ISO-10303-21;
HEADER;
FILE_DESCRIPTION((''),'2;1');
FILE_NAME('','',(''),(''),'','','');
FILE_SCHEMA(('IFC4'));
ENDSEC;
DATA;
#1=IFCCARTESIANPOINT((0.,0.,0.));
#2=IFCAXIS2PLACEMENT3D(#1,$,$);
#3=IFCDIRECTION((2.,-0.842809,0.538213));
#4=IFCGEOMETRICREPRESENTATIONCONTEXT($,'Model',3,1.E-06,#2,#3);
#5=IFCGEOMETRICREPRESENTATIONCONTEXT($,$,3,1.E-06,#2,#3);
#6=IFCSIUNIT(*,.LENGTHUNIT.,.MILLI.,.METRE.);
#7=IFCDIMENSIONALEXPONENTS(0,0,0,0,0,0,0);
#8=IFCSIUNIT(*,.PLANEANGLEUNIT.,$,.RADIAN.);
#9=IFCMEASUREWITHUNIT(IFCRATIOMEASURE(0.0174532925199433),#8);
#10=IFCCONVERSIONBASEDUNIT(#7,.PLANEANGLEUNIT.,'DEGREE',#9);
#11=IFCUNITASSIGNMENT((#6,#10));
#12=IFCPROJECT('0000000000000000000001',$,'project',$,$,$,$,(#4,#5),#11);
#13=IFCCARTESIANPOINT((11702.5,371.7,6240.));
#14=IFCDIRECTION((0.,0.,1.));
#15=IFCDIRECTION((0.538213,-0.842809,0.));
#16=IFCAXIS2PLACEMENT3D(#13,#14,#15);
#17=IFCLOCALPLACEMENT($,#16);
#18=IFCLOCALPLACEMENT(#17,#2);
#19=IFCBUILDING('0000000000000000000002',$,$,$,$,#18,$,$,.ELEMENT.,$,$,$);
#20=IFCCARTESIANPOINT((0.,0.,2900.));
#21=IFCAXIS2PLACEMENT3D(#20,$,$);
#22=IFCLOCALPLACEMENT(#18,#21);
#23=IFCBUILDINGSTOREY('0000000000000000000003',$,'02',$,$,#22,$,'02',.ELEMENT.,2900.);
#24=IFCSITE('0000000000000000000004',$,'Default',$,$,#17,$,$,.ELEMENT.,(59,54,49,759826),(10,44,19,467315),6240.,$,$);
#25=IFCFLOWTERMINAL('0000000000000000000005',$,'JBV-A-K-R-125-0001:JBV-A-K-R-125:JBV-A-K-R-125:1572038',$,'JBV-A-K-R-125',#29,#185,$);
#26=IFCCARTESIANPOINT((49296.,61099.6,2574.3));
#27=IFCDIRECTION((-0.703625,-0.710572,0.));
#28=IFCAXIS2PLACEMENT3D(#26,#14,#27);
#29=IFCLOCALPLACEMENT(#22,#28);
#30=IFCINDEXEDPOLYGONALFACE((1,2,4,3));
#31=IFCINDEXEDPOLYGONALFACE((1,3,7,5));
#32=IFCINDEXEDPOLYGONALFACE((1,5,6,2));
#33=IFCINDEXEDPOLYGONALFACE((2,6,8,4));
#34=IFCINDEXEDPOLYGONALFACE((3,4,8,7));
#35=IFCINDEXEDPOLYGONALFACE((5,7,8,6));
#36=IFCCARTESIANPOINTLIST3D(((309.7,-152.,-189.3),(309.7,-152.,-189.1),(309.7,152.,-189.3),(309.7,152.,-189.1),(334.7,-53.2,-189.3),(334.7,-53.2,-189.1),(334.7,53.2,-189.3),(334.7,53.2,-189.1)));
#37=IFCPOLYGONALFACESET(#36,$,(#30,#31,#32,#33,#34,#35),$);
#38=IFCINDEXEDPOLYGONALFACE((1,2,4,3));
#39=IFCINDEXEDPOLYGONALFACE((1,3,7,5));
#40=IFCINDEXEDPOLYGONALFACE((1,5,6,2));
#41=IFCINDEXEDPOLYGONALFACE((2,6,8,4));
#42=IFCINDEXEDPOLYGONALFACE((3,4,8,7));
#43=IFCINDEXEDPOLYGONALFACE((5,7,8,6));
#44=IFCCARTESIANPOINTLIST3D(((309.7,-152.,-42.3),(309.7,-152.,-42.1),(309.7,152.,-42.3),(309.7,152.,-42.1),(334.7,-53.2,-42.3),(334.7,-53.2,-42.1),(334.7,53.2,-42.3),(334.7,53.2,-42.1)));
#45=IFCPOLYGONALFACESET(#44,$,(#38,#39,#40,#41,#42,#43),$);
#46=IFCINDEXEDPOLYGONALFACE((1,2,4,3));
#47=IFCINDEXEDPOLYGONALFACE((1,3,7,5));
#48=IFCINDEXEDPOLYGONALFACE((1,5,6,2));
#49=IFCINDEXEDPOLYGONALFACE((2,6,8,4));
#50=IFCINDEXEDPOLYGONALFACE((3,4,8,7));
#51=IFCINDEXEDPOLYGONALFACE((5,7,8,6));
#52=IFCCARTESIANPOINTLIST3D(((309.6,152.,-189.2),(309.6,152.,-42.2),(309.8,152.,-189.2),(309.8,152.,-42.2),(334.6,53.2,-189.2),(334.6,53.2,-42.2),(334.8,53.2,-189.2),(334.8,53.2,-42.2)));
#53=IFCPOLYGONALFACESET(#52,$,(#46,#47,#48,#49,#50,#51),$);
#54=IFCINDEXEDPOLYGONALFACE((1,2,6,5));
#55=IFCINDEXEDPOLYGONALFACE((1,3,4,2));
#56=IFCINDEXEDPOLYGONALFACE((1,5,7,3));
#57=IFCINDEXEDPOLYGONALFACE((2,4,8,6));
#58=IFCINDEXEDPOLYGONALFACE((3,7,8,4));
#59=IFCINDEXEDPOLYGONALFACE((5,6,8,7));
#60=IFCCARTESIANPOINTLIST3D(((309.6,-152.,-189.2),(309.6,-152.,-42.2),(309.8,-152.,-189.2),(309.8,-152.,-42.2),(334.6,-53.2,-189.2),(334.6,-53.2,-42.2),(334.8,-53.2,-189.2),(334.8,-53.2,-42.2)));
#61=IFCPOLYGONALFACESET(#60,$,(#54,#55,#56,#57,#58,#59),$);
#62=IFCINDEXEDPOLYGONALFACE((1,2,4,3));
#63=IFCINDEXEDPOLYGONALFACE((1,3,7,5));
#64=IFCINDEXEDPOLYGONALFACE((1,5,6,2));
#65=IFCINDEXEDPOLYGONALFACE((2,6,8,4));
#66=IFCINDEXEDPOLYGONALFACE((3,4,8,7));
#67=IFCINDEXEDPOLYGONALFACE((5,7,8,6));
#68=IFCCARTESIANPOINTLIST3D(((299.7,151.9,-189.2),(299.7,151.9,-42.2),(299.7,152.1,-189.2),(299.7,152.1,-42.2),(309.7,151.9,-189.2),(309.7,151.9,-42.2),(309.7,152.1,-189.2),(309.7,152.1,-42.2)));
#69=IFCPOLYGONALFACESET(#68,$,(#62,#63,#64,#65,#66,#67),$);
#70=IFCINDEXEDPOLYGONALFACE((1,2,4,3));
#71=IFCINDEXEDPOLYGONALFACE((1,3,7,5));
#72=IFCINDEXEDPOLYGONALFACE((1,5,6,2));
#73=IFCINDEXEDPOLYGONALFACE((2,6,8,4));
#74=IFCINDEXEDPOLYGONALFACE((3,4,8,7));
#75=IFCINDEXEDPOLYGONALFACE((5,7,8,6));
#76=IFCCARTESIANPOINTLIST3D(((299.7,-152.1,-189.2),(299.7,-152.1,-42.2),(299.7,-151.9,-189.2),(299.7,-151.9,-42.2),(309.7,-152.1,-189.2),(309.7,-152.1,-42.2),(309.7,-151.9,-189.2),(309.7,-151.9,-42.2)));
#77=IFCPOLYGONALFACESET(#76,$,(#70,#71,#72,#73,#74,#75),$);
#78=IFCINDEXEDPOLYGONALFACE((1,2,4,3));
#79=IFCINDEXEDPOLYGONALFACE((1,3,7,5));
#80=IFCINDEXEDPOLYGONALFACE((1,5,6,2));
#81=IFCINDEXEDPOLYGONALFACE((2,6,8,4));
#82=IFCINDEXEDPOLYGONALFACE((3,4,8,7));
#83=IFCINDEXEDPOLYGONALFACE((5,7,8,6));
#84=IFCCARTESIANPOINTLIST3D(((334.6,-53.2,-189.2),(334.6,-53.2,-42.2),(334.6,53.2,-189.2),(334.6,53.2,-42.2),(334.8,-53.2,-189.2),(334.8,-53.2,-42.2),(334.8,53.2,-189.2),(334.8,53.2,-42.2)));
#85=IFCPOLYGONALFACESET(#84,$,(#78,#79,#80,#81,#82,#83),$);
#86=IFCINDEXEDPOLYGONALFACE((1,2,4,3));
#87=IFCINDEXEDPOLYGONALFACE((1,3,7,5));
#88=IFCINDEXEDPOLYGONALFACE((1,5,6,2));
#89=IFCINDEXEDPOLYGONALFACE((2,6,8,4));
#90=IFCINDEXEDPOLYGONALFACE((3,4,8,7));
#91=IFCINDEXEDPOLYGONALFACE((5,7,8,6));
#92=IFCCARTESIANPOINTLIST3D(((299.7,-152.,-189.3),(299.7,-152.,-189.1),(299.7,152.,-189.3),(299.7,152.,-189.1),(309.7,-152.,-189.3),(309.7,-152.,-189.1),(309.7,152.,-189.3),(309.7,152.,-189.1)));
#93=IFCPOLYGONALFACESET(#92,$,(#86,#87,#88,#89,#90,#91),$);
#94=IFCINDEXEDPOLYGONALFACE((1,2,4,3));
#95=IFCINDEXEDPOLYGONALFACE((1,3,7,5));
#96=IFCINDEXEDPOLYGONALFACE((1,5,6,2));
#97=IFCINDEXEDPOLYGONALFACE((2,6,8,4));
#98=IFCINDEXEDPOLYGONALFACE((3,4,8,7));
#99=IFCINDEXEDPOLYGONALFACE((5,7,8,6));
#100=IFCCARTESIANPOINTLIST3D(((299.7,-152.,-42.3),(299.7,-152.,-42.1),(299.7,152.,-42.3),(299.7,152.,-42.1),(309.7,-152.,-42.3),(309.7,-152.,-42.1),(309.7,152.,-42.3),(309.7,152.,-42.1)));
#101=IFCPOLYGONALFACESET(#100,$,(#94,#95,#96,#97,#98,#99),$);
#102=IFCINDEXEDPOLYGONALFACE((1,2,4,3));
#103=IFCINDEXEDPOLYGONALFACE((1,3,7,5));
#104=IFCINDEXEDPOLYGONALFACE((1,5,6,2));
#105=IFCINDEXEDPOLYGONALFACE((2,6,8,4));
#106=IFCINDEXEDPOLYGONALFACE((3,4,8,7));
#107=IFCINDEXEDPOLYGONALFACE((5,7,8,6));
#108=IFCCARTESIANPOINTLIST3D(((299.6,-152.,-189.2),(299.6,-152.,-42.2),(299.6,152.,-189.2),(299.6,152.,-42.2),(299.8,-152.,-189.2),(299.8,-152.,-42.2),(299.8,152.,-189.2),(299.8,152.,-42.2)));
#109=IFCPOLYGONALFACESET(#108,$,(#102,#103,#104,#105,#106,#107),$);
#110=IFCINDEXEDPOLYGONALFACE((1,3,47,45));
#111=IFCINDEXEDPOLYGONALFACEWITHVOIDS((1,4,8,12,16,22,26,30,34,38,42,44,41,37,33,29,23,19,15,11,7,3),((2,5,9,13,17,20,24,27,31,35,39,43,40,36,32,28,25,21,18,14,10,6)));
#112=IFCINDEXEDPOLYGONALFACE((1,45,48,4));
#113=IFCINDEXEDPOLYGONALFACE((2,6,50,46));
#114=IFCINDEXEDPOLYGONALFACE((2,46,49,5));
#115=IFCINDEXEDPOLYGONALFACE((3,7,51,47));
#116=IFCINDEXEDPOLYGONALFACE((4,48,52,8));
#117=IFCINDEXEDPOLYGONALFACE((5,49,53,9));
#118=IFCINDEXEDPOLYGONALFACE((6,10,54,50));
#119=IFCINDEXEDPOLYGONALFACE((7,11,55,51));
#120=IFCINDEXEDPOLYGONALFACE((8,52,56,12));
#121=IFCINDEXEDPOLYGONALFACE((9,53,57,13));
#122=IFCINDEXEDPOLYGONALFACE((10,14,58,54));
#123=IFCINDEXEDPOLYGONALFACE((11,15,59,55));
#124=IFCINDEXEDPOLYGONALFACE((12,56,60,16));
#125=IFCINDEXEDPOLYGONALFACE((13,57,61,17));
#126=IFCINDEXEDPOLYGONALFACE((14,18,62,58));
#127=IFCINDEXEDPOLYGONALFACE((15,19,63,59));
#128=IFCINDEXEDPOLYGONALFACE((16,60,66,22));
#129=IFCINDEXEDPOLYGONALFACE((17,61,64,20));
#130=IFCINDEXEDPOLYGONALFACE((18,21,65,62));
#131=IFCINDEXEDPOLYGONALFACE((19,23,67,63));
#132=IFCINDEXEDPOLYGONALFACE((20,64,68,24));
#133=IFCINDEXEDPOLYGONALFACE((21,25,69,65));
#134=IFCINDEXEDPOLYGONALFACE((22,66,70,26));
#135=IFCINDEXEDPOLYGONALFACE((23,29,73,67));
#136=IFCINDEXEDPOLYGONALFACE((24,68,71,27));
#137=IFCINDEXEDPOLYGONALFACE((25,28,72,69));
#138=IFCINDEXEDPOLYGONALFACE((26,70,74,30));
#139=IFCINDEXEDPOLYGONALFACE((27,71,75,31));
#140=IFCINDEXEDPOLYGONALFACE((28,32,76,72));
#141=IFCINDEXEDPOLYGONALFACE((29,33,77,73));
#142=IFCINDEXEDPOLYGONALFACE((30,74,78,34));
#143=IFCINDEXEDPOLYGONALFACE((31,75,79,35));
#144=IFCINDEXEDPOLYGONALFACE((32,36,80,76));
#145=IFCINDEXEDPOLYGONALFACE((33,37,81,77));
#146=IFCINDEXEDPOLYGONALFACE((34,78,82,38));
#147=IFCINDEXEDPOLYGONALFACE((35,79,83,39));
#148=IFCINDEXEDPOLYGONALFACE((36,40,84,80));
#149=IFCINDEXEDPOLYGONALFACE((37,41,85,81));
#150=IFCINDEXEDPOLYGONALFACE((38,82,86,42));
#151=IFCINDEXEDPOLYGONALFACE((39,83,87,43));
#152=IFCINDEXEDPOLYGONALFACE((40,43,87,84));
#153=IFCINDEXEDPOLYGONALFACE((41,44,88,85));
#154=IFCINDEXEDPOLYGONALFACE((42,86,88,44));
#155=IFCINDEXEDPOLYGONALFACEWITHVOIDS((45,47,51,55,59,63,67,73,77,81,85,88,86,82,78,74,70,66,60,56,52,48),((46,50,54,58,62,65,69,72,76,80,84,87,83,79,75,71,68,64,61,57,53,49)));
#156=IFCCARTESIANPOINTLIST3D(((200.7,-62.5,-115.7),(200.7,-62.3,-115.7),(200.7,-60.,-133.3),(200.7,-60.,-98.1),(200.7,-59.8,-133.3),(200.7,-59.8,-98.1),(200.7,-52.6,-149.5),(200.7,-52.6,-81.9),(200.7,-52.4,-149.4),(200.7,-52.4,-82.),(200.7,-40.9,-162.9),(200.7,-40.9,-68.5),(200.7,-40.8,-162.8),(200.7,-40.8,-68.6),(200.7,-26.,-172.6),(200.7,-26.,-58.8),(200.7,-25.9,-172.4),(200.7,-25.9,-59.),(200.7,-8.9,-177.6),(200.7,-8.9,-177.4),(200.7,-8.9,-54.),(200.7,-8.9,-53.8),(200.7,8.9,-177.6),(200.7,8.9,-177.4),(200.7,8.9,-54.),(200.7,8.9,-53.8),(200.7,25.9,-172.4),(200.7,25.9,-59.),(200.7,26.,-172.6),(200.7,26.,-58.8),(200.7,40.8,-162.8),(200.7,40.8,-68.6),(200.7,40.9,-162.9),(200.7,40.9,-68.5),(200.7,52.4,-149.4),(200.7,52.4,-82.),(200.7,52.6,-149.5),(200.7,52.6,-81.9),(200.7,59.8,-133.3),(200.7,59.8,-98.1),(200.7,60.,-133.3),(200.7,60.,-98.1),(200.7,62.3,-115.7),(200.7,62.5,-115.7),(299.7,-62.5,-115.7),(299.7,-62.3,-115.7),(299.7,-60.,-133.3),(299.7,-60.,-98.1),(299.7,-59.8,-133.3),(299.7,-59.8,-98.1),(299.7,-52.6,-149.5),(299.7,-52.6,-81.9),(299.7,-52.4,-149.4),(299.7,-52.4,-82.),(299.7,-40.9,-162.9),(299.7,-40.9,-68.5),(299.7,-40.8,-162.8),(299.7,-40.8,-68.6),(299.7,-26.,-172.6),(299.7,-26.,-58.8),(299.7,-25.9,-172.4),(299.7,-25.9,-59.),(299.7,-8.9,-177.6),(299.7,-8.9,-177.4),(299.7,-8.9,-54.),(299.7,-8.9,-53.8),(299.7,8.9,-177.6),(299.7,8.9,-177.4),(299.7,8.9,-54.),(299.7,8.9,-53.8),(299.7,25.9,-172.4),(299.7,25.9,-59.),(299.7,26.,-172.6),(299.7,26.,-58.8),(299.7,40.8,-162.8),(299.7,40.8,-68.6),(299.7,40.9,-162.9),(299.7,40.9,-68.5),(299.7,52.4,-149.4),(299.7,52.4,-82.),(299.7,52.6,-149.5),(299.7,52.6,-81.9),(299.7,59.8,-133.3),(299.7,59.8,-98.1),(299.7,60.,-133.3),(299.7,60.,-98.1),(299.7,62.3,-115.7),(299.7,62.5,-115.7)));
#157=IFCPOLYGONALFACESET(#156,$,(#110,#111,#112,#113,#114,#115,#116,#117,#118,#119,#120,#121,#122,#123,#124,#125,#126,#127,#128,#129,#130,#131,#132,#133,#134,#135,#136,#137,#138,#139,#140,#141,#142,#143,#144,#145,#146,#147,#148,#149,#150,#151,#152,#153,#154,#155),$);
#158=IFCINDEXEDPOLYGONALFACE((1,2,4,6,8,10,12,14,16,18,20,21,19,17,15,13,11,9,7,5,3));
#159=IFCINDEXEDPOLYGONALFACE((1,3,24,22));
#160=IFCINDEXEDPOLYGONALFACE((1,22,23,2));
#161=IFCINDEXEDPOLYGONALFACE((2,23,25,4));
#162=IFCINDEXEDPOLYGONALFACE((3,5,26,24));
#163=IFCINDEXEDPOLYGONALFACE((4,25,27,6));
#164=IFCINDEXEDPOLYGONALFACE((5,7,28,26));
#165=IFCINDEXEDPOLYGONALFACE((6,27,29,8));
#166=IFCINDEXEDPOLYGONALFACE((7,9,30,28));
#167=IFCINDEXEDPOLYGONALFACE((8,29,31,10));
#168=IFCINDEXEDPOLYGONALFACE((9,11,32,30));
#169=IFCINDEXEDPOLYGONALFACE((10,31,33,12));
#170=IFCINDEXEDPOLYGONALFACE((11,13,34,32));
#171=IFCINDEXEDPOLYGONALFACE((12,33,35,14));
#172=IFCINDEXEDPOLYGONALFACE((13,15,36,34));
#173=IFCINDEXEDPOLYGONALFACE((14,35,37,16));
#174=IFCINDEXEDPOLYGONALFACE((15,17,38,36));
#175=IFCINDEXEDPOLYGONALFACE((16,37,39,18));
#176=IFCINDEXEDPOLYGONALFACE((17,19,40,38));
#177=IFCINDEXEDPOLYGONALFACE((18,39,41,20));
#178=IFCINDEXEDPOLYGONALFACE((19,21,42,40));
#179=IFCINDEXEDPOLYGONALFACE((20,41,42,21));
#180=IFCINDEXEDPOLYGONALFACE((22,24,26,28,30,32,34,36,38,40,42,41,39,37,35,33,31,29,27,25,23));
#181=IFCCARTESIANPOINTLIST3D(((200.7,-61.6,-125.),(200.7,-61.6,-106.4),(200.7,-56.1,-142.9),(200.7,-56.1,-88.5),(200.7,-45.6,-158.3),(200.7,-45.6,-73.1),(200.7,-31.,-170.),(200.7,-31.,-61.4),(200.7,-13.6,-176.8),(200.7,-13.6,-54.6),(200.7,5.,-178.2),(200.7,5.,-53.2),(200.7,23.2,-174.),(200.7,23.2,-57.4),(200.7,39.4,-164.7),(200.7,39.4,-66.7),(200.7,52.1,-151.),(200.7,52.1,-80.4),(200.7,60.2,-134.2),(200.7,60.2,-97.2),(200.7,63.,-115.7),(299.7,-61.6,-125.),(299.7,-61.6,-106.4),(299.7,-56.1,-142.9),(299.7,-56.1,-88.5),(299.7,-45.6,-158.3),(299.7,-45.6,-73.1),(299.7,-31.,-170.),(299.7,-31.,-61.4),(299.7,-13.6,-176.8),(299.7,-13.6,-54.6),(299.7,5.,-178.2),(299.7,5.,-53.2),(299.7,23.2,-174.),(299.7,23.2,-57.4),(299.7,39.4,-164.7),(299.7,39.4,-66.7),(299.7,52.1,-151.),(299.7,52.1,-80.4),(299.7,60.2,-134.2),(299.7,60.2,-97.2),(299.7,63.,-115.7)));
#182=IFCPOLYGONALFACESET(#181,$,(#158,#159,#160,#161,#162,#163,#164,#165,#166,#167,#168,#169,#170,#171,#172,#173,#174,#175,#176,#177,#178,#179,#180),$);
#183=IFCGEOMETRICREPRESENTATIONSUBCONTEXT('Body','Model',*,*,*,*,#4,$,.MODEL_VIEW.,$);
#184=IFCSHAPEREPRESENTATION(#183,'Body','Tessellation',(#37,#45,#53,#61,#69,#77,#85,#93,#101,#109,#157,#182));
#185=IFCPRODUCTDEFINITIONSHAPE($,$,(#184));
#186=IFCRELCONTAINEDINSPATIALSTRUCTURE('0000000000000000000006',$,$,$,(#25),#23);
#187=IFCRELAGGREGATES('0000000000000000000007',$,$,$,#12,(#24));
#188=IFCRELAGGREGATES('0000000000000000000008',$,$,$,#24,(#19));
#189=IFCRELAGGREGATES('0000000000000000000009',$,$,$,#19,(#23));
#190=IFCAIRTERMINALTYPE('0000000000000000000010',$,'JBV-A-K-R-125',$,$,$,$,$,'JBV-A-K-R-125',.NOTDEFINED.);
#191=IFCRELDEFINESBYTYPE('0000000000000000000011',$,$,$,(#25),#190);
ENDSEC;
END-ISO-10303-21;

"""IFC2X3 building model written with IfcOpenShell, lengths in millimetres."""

from ifc_helpers import new_model, entity, si_unit, converted_unit, direction, frame, frame_2d, origin, origin_2d_with_axis, place, context, subcontext, project, spatial, polyline, circle_curve, parameter, trimmed, segment, composite_curve, rectangle, circle, outline, extrude, source, transform, mapped, type_object, type_shapes, element, save


model = new_model("IFC2X3")

# Units and contexts
model_context = context("Model", 3, precision=1e-06, world=origin(), true_north=direction((2.0, -0.842809, 0.538213)))
context_of_model = context(None, 3, precision=1e-06, world=origin(), true_north=direction((2.0, -0.842809, 0.538213)))
body_context = subcontext(model_context, "Body", "Model", "MODEL_VIEW")
ifc_project = project(units=[si_unit("LENGTHUNIT", "METRE", prefix="MILLI"), converted_unit("PLANEANGLEUNIT", "DEGREE", entity("IfcRatioMeasure", 0.0174532925199433), si_unit("PLANEANGLEUNIT", "RADIAN"), dimensions=[0, 0, 0, 0, 0, 0, 0])], contexts=[model_context, context_of_model])

# Site, building, storey
site_placement = place(None, frame((11702.5, 371.7, 6240.0), z_axis=(0.0, 0.0, 1.0), x_axis=(0.538213, -0.842809, 0.0)))
site = spatial("IfcSite", under=ifc_project, at=site_placement, Name="Default", CompositionType="ELEMENT", RefLatitude=(59, 54, 49, 759826), RefLongitude=(10, 44, 19, 467315), RefElevation=6240.0)
building_placement = place(site_placement, origin())
building = spatial("IfcBuilding", under=site, at=building_placement, CompositionType="ELEMENT")
storey_placement = place(building_placement, frame((0.0, 0.0, 2900.0)))
storey = spatial("IfcBuildingStorey", under=building, at=storey_placement, Name="02", LongName="02", CompositionType="ELEMENT", Elevation=2900.0)

# Flow terminal
air_terminal_type_1 = type_object("IfcAirTerminalType", Name="JBV-A-K-R-125", ElementType="JBV-A-K-R-125", PredefinedType="NOTDEFINED")
shared_shape_1 = source(origin(), body_context, "Body", "SweptSolid", [
    extrude(outline(polyline([(-152.0, -12.5), (152.0, -12.5), (53.2, 12.5), (-53.2, 12.5), (-152.0, -12.5)])), frame((322.2, 0.0, -189.3), z_axis=(0.0, 0.0, 1.0), x_axis=(0.0, -1.0, 0.0)), (0.0, 0.0, 1.0), 0.2),
    extrude(outline(polyline([(-152.0, -12.5), (152.0, -12.5), (53.2, 12.5), (-53.2, 12.5), (-152.0, -12.5)])), frame((322.2, 0.0, -42.3), z_axis=(0.0, 0.0, 1.0), x_axis=(0.0, -1.0, 0.0)), (0.0, 0.0, 1.0), 0.2),
    extrude(rectangle(XDim=0.2, YDim=101.9, at=frame_2d((0.0, 0.0), x_axis=(1.0, 0.0))), frame((322.2, 102.6, -189.2), z_axis=(0.0, 0.0, 1.0), x_axis=(0.969446, 0.245305, 0.0)), (0.0, 0.0, 1.0), 147.0),
    extrude(rectangle(XDim=0.2, YDim=101.9, at=frame_2d((0.0, 0.0), x_axis=(1.0, 0.0))), frame((322.2, -102.6, -189.2), z_axis=(0.0, 0.0, 1.0), x_axis=(-0.969446, 0.245305, 0.0)), (0.0, 0.0, 1.0), 147.0),
    extrude(rectangle(XDim=0.2, YDim=10.0, at=frame_2d((0.0, 0.0), x_axis=(1.0, 0.0))), frame((304.7, 152.0, -189.2), z_axis=(0.0, 0.0, 1.0), x_axis=(0.0, 1.0, 0.0)), (0.0, 0.0, 1.0), 147.0),
    extrude(rectangle(XDim=0.2, YDim=10.0, at=frame_2d((0.0, 0.0), x_axis=(1.0, 0.0))), frame((304.7, -152.0, -189.2), z_axis=(0.0, 0.0, 1.0), x_axis=(0.0, 1.0, 0.0)), (0.0, 0.0, 1.0), 147.0),
    extrude(rectangle(XDim=0.2, YDim=106.4, at=frame_2d((0.0, 0.0), x_axis=(1.0, 0.0))), frame((334.7, 0.0, -189.2)), (0.0, 0.0, 1.0), 147.0),
    extrude(rectangle(XDim=304.0, YDim=10.0, at=frame_2d((0.0, 0.0), x_axis=(1.0, 0.0))), frame((304.7, 0.0, -189.3), z_axis=(0.0, 0.0, 1.0), x_axis=(0.0, -1.0, 0.0)), (0.0, 0.0, 1.0), 0.2),
    extrude(rectangle(XDim=304.0, YDim=10.0, at=frame_2d((0.0, 0.0), x_axis=(1.0, 0.0))), frame((304.7, 0.0, -42.3), z_axis=(0.0, 0.0, 1.0), x_axis=(0.0, -1.0, 0.0)), (0.0, 0.0, 1.0), 0.2),
    extrude(rectangle(XDim=0.2, YDim=304.0, at=frame_2d((0.0, 0.0), x_axis=(1.0, 0.0))), frame((299.7, 0.0, -189.2)), (0.0, 0.0, 1.0), 147.0),
    extrude(outline(composite_curve([segment(trimmed(circle_curve(origin_2d_with_axis(), 62.5), [parameter(0.0)], [parameter(180.0)], True, "PARAMETER"), True, "CONTINUOUS"), segment(trimmed(circle_curve(origin_2d_with_axis(), 62.5), [parameter(180.0)], [parameter(360.0)], True, "PARAMETER"), True, "CONTINUOUS")], self_intersect=False), holes=[composite_curve([segment(trimmed(circle_curve(origin_2d_with_axis(), 62.3), [parameter(180.0)], [parameter(360.0)], True, "PARAMETER"), False, "CONTINUOUS"), segment(trimmed(circle_curve(origin_2d_with_axis(), 62.3), [parameter(0.0)], [parameter(180.0)], True, "PARAMETER"), False, "CONTINUOUS")], self_intersect=False)]), frame((200.7, 0.0, -115.7), z_axis=(1.0, 0.0, 0.0), x_axis=(0.0, 1.0, 0.0)), (0.0, 0.0, 1.0), 99.0),
    extrude(circle(Radius=62.6, at=frame_2d((0.0, 0.0), x_axis=(1.0, 0.0))), frame((200.7, 0.3, -115.7), z_axis=(1.0, 0.0, 0.0), x_axis=(0.0, 1.0, 0.0)), (0.0, 0.0, 1.0), 99.0),
])
type_shapes(air_terminal_type_1, [shared_shape_1])
flow_terminal_1_placement = place(storey_placement, frame((49296.0, 61099.6, 2574.3), z_axis=(0.0, 0.0, 1.0), x_axis=(-0.703625, -0.710572, 0.0)))
element("IfcFlowTerminal", 1, at=flow_terminal_1_placement, inside=storey, type_object=air_terminal_type_1, Name="JBV-A-K-R-125-0001:JBV-A-K-R-125:JBV-A-K-R-125:1572038", ObjectType="JBV-A-K-R-125", context=body_context, shape_type="MappedRepresentation", body=[
    mapped(shared_shape_1, transform((0.0, 0.0, 0.0), scale=1.0)),
])

save(model, "model.ifc")
